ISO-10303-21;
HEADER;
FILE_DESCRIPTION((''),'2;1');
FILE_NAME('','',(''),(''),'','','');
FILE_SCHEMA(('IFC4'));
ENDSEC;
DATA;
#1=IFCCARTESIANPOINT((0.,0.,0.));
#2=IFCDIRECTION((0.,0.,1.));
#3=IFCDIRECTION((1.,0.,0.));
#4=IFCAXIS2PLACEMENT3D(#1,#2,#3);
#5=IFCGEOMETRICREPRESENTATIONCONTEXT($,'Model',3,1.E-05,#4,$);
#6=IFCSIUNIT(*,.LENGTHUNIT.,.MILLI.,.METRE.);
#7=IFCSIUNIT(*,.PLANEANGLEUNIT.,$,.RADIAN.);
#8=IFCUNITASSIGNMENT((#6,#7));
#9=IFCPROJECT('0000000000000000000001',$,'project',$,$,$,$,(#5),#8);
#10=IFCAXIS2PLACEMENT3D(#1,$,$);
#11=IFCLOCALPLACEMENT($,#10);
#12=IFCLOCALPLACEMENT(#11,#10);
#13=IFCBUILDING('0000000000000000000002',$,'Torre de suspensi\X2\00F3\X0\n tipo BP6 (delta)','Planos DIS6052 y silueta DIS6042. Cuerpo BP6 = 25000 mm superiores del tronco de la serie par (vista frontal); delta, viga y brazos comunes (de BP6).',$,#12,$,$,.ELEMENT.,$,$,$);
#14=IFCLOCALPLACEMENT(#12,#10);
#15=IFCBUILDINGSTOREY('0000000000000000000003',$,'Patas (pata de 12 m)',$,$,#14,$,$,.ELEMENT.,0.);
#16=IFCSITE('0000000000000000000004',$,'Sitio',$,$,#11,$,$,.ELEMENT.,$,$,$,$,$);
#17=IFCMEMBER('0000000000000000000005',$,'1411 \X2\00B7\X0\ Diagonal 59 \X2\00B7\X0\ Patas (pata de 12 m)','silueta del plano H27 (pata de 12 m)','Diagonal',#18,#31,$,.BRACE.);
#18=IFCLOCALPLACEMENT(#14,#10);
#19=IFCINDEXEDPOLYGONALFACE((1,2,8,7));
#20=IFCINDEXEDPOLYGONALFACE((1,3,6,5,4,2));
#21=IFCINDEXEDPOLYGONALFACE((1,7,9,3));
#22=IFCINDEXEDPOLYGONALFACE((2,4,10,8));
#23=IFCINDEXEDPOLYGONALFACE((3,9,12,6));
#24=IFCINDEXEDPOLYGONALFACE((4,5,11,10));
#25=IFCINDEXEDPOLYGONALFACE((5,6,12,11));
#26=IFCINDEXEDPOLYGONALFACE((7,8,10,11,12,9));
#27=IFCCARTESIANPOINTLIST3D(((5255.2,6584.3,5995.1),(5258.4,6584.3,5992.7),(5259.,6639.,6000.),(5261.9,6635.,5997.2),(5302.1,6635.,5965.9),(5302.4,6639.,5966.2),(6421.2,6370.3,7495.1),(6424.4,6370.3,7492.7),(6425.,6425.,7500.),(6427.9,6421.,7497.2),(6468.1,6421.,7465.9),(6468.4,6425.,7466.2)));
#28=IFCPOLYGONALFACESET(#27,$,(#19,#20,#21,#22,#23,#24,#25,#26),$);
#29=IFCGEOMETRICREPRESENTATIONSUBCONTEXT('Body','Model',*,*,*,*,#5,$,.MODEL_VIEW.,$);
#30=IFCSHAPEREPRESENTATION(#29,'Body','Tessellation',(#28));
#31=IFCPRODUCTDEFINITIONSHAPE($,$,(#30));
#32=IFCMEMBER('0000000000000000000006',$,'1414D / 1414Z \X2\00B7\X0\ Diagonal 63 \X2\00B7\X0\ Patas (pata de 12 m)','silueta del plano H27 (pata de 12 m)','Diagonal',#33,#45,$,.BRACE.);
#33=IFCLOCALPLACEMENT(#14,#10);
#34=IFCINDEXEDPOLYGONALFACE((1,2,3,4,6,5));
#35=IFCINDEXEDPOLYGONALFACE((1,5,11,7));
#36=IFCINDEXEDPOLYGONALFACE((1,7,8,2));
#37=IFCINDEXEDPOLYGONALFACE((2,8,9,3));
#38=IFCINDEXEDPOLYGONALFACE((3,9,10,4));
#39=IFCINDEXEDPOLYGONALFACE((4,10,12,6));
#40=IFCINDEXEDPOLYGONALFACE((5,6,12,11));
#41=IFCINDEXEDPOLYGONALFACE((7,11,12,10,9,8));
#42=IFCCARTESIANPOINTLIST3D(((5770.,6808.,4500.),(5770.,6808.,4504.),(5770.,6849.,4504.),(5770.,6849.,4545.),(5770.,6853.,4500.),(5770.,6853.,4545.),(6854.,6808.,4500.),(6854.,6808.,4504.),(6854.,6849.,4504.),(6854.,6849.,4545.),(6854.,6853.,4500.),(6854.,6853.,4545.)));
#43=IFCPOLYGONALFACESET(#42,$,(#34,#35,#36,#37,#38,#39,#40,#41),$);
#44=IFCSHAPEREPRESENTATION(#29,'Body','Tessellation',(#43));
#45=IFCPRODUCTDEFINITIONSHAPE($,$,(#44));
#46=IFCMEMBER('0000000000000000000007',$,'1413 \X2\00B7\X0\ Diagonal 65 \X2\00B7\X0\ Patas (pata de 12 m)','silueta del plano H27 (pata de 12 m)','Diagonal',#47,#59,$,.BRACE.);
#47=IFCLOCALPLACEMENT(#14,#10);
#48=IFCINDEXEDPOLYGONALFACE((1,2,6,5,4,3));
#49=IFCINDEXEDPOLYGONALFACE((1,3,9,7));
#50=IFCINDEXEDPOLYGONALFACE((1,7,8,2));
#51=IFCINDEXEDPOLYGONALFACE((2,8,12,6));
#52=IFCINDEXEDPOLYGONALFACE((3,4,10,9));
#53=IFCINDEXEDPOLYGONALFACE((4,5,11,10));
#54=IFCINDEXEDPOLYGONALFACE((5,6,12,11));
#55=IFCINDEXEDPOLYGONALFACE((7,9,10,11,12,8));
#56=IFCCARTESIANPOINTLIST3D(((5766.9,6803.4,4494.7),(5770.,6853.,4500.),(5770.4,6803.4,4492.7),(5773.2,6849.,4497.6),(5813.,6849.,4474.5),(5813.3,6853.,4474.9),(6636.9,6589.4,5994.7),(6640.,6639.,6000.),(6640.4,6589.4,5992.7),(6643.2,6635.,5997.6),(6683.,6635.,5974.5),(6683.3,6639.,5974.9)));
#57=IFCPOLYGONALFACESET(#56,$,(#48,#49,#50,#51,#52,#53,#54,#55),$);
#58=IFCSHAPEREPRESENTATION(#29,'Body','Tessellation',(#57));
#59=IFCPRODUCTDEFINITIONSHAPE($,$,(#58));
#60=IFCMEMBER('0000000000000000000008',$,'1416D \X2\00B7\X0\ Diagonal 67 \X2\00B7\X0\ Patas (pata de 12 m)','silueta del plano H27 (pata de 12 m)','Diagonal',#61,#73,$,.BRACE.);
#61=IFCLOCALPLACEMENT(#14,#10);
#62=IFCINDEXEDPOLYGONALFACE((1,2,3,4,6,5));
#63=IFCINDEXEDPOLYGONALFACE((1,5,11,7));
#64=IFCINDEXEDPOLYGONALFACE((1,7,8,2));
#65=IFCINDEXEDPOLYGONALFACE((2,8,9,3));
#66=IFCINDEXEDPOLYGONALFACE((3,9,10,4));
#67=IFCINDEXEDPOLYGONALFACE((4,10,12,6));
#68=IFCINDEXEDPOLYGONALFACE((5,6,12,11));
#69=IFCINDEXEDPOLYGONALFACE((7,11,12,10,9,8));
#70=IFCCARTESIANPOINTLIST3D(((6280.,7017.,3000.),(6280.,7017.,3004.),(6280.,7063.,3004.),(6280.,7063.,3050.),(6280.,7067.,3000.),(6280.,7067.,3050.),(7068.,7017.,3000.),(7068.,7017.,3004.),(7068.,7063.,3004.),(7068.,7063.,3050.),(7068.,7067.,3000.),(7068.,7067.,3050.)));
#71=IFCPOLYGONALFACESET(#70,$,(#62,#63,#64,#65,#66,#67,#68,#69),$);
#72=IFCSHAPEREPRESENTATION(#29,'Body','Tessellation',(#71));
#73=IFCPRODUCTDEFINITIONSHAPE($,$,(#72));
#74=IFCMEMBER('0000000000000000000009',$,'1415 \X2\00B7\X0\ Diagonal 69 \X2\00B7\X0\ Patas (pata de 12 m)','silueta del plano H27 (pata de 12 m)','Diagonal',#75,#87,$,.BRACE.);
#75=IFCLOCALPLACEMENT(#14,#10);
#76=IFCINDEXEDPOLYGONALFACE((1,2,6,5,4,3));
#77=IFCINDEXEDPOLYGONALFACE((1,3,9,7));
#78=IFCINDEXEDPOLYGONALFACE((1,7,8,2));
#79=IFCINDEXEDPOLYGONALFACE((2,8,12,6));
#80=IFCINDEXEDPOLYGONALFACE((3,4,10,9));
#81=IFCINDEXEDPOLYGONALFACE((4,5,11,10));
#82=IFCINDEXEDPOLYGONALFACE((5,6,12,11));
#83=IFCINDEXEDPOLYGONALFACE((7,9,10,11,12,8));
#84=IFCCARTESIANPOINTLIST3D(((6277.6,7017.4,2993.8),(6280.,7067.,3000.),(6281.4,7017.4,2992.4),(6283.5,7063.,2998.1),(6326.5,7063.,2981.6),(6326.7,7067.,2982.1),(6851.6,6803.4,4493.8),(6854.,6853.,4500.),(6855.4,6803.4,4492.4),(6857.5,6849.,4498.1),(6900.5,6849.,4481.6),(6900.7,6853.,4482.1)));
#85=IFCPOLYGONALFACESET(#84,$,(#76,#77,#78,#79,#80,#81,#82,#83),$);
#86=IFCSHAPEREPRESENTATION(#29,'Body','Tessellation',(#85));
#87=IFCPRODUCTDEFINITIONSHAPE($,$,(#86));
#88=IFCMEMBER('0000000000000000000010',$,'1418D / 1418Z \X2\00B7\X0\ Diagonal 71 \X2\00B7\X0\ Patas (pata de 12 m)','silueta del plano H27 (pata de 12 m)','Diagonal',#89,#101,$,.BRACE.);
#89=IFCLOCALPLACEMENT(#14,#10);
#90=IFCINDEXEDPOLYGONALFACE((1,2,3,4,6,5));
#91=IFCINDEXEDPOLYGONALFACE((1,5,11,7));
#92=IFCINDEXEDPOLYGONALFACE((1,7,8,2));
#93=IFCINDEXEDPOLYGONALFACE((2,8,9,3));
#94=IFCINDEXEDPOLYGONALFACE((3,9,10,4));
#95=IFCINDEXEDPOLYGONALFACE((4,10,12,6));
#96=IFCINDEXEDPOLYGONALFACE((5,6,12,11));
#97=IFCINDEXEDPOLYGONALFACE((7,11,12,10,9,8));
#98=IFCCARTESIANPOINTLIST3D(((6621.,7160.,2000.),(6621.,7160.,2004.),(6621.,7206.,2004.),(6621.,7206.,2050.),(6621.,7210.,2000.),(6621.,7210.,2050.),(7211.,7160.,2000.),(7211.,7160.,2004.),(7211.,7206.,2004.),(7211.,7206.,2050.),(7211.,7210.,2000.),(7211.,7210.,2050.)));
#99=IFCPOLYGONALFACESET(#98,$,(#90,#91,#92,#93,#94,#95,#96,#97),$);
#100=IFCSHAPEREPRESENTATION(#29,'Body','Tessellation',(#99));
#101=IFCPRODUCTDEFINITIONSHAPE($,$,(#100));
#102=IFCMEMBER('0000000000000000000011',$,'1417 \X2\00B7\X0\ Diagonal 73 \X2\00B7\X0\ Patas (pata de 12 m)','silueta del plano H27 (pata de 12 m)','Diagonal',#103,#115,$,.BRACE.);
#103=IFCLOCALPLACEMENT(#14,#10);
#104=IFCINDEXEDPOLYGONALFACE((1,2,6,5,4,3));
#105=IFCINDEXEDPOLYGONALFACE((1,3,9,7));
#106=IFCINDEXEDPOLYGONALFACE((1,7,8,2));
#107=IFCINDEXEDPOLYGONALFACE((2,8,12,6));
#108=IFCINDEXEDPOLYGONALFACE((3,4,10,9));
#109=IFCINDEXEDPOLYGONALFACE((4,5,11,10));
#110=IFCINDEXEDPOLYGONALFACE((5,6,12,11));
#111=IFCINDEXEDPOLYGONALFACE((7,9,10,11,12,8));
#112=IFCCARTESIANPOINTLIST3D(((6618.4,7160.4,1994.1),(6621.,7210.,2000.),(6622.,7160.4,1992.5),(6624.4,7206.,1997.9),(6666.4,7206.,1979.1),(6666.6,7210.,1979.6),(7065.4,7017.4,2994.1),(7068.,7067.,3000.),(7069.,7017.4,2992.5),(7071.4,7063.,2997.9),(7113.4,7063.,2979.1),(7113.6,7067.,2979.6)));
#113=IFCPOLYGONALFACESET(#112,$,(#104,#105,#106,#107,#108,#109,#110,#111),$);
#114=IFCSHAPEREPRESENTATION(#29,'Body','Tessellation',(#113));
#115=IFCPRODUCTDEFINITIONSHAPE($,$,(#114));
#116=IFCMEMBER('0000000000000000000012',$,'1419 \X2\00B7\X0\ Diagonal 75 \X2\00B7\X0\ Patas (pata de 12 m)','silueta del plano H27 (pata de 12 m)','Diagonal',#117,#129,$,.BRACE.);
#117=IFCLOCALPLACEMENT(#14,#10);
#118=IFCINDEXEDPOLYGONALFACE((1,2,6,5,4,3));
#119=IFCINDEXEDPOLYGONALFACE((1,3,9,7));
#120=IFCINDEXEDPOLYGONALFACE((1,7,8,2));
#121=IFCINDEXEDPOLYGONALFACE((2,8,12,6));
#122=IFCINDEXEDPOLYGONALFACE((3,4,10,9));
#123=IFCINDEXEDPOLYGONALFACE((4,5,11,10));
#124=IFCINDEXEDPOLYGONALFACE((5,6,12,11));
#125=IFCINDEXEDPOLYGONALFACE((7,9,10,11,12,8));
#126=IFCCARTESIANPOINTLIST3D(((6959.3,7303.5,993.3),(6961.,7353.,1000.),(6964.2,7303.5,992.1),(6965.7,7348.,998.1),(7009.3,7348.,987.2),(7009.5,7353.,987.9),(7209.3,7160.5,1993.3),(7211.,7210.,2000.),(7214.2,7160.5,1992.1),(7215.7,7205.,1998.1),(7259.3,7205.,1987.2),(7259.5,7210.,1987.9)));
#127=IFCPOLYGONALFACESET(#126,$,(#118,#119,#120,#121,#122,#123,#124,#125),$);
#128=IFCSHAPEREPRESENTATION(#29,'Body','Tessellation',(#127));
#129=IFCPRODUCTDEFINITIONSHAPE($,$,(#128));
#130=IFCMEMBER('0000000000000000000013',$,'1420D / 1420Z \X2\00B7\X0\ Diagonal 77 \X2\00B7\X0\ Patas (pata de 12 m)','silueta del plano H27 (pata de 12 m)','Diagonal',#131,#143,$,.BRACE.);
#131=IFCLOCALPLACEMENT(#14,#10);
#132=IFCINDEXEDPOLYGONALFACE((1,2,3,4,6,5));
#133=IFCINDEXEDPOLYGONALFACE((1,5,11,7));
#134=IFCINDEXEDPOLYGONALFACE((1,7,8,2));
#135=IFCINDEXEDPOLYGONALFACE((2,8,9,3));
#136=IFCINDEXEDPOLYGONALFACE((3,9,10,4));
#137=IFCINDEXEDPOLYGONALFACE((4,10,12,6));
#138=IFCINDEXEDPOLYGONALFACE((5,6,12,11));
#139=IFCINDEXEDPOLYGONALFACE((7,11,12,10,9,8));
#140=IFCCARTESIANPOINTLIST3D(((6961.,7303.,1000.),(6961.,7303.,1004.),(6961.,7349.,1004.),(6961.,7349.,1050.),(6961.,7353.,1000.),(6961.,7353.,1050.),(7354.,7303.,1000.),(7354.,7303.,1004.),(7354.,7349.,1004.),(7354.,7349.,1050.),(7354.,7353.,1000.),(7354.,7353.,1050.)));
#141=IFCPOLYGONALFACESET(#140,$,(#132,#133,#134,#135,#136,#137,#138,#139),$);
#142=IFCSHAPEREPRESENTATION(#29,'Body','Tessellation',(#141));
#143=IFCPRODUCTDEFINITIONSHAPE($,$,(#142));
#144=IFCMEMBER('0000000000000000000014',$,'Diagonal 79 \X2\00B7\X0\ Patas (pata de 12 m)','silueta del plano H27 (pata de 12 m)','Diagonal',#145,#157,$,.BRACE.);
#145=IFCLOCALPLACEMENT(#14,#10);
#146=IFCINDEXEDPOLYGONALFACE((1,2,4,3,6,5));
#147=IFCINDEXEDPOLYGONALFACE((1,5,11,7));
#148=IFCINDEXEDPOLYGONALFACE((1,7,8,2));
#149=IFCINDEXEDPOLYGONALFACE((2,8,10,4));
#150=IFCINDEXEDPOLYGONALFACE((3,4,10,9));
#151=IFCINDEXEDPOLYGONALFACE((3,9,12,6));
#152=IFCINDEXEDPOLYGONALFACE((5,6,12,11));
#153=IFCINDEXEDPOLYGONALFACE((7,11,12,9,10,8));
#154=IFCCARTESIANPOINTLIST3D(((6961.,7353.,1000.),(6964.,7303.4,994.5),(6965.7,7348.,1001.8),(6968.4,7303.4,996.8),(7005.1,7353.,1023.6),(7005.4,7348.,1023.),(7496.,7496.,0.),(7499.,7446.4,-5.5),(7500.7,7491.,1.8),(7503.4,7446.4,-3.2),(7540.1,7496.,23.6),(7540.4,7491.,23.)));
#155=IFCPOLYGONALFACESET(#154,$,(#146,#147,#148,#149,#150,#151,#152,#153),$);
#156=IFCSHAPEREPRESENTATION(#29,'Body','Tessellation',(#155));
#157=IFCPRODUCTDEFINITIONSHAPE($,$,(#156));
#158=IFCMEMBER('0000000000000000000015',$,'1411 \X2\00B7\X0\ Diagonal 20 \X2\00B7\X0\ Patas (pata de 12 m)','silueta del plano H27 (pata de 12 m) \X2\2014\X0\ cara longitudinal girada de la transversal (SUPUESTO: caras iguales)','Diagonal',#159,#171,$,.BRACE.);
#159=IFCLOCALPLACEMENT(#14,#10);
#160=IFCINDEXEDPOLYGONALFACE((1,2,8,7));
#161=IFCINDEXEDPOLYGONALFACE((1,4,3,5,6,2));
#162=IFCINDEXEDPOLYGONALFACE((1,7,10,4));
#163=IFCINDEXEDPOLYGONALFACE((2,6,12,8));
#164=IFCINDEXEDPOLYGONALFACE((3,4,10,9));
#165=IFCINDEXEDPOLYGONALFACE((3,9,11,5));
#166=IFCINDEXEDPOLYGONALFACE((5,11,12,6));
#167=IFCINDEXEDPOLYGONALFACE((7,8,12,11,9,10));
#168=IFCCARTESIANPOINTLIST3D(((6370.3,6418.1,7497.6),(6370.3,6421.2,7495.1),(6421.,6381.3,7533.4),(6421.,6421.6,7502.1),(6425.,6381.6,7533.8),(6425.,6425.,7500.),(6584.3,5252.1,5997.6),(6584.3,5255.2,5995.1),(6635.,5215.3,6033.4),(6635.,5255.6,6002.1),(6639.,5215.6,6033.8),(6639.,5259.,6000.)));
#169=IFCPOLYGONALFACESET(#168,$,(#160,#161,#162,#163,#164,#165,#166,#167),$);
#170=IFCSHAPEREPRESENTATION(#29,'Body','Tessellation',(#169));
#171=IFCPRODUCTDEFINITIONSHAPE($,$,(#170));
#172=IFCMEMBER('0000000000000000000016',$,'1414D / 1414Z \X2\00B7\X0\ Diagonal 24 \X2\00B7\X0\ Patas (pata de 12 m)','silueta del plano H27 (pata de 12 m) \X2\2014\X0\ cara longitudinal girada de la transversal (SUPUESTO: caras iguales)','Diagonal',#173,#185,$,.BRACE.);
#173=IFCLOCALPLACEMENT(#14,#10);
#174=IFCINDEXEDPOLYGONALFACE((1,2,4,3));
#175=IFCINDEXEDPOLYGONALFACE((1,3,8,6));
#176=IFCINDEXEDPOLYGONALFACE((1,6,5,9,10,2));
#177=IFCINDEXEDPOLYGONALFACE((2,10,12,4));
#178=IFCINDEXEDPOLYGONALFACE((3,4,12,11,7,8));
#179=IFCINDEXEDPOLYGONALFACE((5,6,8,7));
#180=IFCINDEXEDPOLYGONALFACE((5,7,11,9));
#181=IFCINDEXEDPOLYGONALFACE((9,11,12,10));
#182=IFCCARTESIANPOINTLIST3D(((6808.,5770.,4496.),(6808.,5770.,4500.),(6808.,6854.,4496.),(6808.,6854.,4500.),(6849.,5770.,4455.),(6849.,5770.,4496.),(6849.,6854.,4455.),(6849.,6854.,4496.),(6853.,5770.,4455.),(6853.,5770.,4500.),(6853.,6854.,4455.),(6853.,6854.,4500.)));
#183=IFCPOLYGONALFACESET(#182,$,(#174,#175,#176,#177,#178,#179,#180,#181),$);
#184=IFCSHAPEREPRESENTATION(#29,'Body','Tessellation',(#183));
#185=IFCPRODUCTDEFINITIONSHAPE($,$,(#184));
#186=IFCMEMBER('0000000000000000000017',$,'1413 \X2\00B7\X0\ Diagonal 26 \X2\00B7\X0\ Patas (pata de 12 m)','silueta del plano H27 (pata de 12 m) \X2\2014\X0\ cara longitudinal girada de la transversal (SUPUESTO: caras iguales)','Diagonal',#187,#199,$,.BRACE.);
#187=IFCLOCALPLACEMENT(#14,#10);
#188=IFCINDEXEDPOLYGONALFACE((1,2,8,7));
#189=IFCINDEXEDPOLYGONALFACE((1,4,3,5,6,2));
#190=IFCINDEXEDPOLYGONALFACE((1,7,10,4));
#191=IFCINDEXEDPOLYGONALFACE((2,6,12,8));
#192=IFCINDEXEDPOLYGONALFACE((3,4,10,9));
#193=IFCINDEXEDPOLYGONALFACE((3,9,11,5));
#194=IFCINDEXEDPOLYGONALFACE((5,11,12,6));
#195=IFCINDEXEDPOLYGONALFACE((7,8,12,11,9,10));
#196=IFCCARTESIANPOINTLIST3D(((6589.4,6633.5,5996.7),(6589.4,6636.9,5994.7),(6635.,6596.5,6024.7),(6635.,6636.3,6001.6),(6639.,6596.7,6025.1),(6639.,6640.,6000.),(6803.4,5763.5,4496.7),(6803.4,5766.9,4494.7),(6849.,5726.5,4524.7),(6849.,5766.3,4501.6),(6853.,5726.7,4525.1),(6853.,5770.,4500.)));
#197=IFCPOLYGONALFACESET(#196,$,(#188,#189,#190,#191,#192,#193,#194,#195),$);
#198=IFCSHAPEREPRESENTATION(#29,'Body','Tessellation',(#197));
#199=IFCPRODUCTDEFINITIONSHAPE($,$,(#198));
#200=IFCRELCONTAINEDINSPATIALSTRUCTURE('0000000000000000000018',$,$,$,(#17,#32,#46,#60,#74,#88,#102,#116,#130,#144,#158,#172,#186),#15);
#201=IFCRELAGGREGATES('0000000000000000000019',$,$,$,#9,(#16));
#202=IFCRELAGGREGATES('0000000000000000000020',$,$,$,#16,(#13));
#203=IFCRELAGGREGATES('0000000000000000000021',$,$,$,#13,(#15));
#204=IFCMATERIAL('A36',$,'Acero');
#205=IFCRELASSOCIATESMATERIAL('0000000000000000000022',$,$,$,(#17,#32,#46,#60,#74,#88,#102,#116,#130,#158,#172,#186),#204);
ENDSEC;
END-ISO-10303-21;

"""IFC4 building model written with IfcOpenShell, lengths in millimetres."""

from ifc_helpers import new_model, si_unit, frame, frame_2d, origin, origin_with_axes, place, context, subcontext, project, spatial, l_section, extrude, material, element, save


model = new_model("IFC4")

# Units and contexts
model_context = context("Model", 3, precision=1e-05, world=origin_with_axes())
body_context = subcontext(model_context, "Body", "Model", "MODEL_VIEW")
ifc_project = project(units=[si_unit("LENGTHUNIT", "METRE", prefix="MILLI"), si_unit("PLANEANGLEUNIT", "RADIAN")], contexts=[model_context])

# Site, building, storey
site_placement = place(None, origin())
site = spatial("IfcSite", under=ifc_project, at=site_placement, Name="Sitio", CompositionType="ELEMENT")
building_placement = place(site_placement, origin())
building = spatial("IfcBuilding", under=site, at=building_placement, Name="Torre de suspensión tipo BP6 (delta)", Description="Planos DIS6052 y silueta DIS6042. Cuerpo BP6 = 25000 mm superiores del tronco de la serie par (vista frontal); delta, viga y brazos comunes (de BP6).", CompositionType="ELEMENT")
storey_placement = place(building_placement, origin())
storey = spatial("IfcBuildingStorey", under=building, at=storey_placement, Name="Patas (pata de 12 m)", CompositionType="ELEMENT", Elevation=0.0)

# Members
ifc_material = material(Name="A36", Category="Acero")
member_1_placement = place(storey_placement, frame((5259.0, 6639.0, 6000.0), z_axis=(0.609865, -0.111931, 0.784561), x_axis=(-0.068694, -0.993716, -0.088372)))
element("IfcMember", 1, at=member_1_placement, inside=storey, material=ifc_material, Name="1411 · Diagonal 59 · Patas (pata de 12 m)", Description="silueta del plano H27 (pata de 12 m)", ObjectType="Diagonal", PredefinedType="BRACE", context=body_context, shape_type="SweptSolid", body=[
    extrude(l_section(Depth=55.0, Width=55.0, Thickness=4.0, at=frame_2d((27.5, 27.5))), None, (0.0, 0.0, 1.0), 1911.9),
])
member_2_placement = place(storey_placement, frame((6854.0, 6853.0, 4500.0), z_axis=(-1.0, 0.0, 0.0), x_axis=(0.0, -1.0, 0.0)))
element("IfcMember", 2, at=member_2_placement, inside=storey, material=ifc_material, Name="1414D / 1414Z · Diagonal 63 · Patas (pata de 12 m)", Description="silueta del plano H27 (pata de 12 m)", ObjectType="Diagonal", PredefinedType="BRACE", context=body_context, shape_type="SweptSolid", body=[
    extrude(l_section(Depth=45.0, Width=45.0, Thickness=4.0, at=frame_2d((22.5, 22.5))), None, (0.0, 0.0, 1.0), 1084.0),
])
member_3_placement = place(storey_placement, frame((5770.0, 6853.0, 4500.0), z_axis=(0.497941, -0.122482, 0.858518), x_axis=(-0.061451, -0.992471, -0.105951)))
element("IfcMember", 3, at=member_3_placement, inside=storey, material=ifc_material, Name="1413 · Diagonal 65 · Patas (pata de 12 m)", Description="silueta del plano H27 (pata de 12 m)", ObjectType="Diagonal", PredefinedType="BRACE", context=body_context, shape_type="SweptSolid", body=[
    extrude(l_section(Depth=50.0, Width=50.0, Thickness=4.0, at=frame_2d((25.0, 25.0))), None, (0.0, 0.0, 1.0), 1747.2),
])
member_4_placement = place(storey_placement, frame((7068.0, 7067.0, 3000.0), z_axis=(-1.0, 0.0, 0.0), x_axis=(0.0, -1.0, 0.0)))
element("IfcMember", 4, at=member_4_placement, inside=storey, material=ifc_material, Name="1416D · Diagonal 67 · Patas (pata de 12 m)", Description="silueta del plano H27 (pata de 12 m)", ObjectType="Diagonal", PredefinedType="BRACE", context=body_context, shape_type="SweptSolid", body=[
    extrude(l_section(Depth=50.0, Width=50.0, Thickness=4.0, at=frame_2d((25.0, 25.0))), None, (0.0, 0.0, 1.0), 788.0),
])
member_5_placement = place(storey_placement, frame((6280.0, 7067.0, 3000.0), z_axis=(0.354262, -0.132077, 0.925772), x_axis=(-0.047203, -0.991239, -0.123354)))
element("IfcMember", 5, at=member_5_placement, inside=storey, material=ifc_material, Name="1415 · Diagonal 69 · Patas (pata de 12 m)", Description="silueta del plano H27 (pata de 12 m)", ObjectType="Diagonal", PredefinedType="BRACE", context=body_context, shape_type="SweptSolid", body=[
    extrude(l_section(Depth=50.0, Width=50.0, Thickness=4.0, at=frame_2d((25.0, 25.0))), None, (0.0, 0.0, 1.0), 1620.3),
])
member_6_placement = place(storey_placement, frame((7211.0, 7210.0, 2000.0), z_axis=(-1.0, 0.0, 0.0), x_axis=(0.0, -1.0, 0.0)))
element("IfcMember", 6, at=member_6_placement, inside=storey, material=ifc_material, Name="1418D / 1418Z · Diagonal 71 · Patas (pata de 12 m)", Description="silueta del plano H27 (pata de 12 m)", ObjectType="Diagonal", PredefinedType="BRACE", context=body_context, shape_type="SweptSolid", body=[
    extrude(l_section(Depth=50.0, Width=50.0, Thickness=4.0, at=frame_2d((25.0, 25.0))), None, (0.0, 0.0, 1.0), 590.0),
])
member_7_placement = place(storey_placement, frame((6621.0, 7210.0, 2000.0), z_axis=(0.404652, -0.129452, 0.905262), x_axis=(-0.052828, -0.991586, -0.118183)))
element("IfcMember", 7, at=member_7_placement, inside=storey, material=ifc_material, Name="1417 · Diagonal 73 · Patas (pata de 12 m)", Description="silueta del plano H27 (pata de 12 m)", ObjectType="Diagonal", PredefinedType="BRACE", context=body_context, shape_type="SweptSolid", body=[
    extrude(l_section(Depth=50.0, Width=50.0, Thickness=4.0, at=frame_2d((25.0, 25.0))), None, (0.0, 0.0, 1.0), 1104.7),
])
member_8_placement = place(storey_placement, frame((6961.0, 7353.0, 1000.0), z_axis=(0.240235, -0.137414, 0.960939), x_axis=(-0.033328, -0.990514, -0.133311)))
element("IfcMember", 8, at=member_8_placement, inside=storey, material=ifc_material, Name="1419 · Diagonal 75 · Patas (pata de 12 m)", Description="silueta del plano H27 (pata de 12 m)", ObjectType="Diagonal", PredefinedType="BRACE", context=body_context, shape_type="SweptSolid", body=[
    extrude(l_section(Depth=50.0, Width=50.0, Thickness=5.0, at=frame_2d((25.0, 25.0))), None, (0.0, 0.0, 1.0), 1040.6),
])
member_9_placement = place(storey_placement, frame((7354.0, 7353.0, 1000.0), z_axis=(-1.0, 0.0, 0.0), x_axis=(0.0, -1.0, 0.0)))
element("IfcMember", 9, at=member_9_placement, inside=storey, material=ifc_material, Name="1420D / 1420Z · Diagonal 77 · Patas (pata de 12 m)", Description="silueta del plano H27 (pata de 12 m)", ObjectType="Diagonal", PredefinedType="BRACE", context=body_context, shape_type="SweptSolid", body=[
    extrude(l_section(Depth=50.0, Width=50.0, Thickness=4.0, at=frame_2d((25.0, 25.0))), None, (0.0, 0.0, 1.0), 393.0),
])
member_10_placement = place(storey_placement, frame((7496.0, 7496.0, 0.0), z_axis=(-0.468026, -0.125099, 0.874815), x_axis=(0.059013, -0.992144, -0.110305)))
element("IfcMember", 10, at=member_10_placement, inside=storey, Name="Diagonal 79 · Patas (pata de 12 m)", Description="silueta del plano H27 (pata de 12 m)", ObjectType="Diagonal", PredefinedType="BRACE", context=body_context, shape_type="SweptSolid", body=[
    extrude(l_section(Depth=50.0, Width=50.0, Thickness=5.0, at=frame_2d((25.0, 25.0))), None, (0.0, 0.0, 1.0), 1143.1),
])
member_11_placement = place(storey_placement, frame((6639.0, 5259.0, 6000.0), z_axis=(-0.111931, 0.609865, 0.784561), x_axis=(-0.993716, -0.068694, -0.088372)))
element("IfcMember", 11, at=member_11_placement, inside=storey, material=ifc_material, Name="1411 · Diagonal 20 · Patas (pata de 12 m)", Description="silueta del plano H27 (pata de 12 m) — cara longitudinal girada de la transversal (SUPUESTO: caras iguales)", ObjectType="Diagonal", PredefinedType="BRACE", context=body_context, shape_type="SweptSolid", body=[
    extrude(l_section(Depth=55.0, Width=55.0, Thickness=4.0, at=frame_2d((27.5, 27.5))), None, (0.0, 0.0, 1.0), 1911.9),
])
member_12_placement = place(storey_placement, frame((6853.0, 6854.0, 4500.0), z_axis=(0.0, -1.0, 0.0), x_axis=(-1.0, 0.0, 0.0)))
element("IfcMember", 12, at=member_12_placement, inside=storey, material=ifc_material, Name="1414D / 1414Z · Diagonal 24 · Patas (pata de 12 m)", Description="silueta del plano H27 (pata de 12 m) — cara longitudinal girada de la transversal (SUPUESTO: caras iguales)", ObjectType="Diagonal", PredefinedType="BRACE", context=body_context, shape_type="SweptSolid", body=[
    extrude(l_section(Depth=45.0, Width=45.0, Thickness=4.0, at=frame_2d((22.5, 22.5))), None, (0.0, 0.0, 1.0), 1084.0),
])
member_13_placement = place(storey_placement, frame((6853.0, 5770.0, 4500.0), z_axis=(-0.122482, 0.497941, 0.858518), x_axis=(-0.992471, -0.061451, -0.105951)))
element("IfcMember", 13, at=member_13_placement, inside=storey, material=ifc_material, Name="1413 · Diagonal 26 · Patas (pata de 12 m)", Description="silueta del plano H27 (pata de 12 m) — cara longitudinal girada de la transversal (SUPUESTO: caras iguales)", ObjectType="Diagonal", PredefinedType="BRACE", context=body_context, shape_type="SweptSolid", body=[
    extrude(l_section(Depth=50.0, Width=50.0, Thickness=4.0, at=frame_2d((25.0, 25.0))), None, (0.0, 0.0, 1.0), 1747.2),
])

save(model, "model.ifc")
